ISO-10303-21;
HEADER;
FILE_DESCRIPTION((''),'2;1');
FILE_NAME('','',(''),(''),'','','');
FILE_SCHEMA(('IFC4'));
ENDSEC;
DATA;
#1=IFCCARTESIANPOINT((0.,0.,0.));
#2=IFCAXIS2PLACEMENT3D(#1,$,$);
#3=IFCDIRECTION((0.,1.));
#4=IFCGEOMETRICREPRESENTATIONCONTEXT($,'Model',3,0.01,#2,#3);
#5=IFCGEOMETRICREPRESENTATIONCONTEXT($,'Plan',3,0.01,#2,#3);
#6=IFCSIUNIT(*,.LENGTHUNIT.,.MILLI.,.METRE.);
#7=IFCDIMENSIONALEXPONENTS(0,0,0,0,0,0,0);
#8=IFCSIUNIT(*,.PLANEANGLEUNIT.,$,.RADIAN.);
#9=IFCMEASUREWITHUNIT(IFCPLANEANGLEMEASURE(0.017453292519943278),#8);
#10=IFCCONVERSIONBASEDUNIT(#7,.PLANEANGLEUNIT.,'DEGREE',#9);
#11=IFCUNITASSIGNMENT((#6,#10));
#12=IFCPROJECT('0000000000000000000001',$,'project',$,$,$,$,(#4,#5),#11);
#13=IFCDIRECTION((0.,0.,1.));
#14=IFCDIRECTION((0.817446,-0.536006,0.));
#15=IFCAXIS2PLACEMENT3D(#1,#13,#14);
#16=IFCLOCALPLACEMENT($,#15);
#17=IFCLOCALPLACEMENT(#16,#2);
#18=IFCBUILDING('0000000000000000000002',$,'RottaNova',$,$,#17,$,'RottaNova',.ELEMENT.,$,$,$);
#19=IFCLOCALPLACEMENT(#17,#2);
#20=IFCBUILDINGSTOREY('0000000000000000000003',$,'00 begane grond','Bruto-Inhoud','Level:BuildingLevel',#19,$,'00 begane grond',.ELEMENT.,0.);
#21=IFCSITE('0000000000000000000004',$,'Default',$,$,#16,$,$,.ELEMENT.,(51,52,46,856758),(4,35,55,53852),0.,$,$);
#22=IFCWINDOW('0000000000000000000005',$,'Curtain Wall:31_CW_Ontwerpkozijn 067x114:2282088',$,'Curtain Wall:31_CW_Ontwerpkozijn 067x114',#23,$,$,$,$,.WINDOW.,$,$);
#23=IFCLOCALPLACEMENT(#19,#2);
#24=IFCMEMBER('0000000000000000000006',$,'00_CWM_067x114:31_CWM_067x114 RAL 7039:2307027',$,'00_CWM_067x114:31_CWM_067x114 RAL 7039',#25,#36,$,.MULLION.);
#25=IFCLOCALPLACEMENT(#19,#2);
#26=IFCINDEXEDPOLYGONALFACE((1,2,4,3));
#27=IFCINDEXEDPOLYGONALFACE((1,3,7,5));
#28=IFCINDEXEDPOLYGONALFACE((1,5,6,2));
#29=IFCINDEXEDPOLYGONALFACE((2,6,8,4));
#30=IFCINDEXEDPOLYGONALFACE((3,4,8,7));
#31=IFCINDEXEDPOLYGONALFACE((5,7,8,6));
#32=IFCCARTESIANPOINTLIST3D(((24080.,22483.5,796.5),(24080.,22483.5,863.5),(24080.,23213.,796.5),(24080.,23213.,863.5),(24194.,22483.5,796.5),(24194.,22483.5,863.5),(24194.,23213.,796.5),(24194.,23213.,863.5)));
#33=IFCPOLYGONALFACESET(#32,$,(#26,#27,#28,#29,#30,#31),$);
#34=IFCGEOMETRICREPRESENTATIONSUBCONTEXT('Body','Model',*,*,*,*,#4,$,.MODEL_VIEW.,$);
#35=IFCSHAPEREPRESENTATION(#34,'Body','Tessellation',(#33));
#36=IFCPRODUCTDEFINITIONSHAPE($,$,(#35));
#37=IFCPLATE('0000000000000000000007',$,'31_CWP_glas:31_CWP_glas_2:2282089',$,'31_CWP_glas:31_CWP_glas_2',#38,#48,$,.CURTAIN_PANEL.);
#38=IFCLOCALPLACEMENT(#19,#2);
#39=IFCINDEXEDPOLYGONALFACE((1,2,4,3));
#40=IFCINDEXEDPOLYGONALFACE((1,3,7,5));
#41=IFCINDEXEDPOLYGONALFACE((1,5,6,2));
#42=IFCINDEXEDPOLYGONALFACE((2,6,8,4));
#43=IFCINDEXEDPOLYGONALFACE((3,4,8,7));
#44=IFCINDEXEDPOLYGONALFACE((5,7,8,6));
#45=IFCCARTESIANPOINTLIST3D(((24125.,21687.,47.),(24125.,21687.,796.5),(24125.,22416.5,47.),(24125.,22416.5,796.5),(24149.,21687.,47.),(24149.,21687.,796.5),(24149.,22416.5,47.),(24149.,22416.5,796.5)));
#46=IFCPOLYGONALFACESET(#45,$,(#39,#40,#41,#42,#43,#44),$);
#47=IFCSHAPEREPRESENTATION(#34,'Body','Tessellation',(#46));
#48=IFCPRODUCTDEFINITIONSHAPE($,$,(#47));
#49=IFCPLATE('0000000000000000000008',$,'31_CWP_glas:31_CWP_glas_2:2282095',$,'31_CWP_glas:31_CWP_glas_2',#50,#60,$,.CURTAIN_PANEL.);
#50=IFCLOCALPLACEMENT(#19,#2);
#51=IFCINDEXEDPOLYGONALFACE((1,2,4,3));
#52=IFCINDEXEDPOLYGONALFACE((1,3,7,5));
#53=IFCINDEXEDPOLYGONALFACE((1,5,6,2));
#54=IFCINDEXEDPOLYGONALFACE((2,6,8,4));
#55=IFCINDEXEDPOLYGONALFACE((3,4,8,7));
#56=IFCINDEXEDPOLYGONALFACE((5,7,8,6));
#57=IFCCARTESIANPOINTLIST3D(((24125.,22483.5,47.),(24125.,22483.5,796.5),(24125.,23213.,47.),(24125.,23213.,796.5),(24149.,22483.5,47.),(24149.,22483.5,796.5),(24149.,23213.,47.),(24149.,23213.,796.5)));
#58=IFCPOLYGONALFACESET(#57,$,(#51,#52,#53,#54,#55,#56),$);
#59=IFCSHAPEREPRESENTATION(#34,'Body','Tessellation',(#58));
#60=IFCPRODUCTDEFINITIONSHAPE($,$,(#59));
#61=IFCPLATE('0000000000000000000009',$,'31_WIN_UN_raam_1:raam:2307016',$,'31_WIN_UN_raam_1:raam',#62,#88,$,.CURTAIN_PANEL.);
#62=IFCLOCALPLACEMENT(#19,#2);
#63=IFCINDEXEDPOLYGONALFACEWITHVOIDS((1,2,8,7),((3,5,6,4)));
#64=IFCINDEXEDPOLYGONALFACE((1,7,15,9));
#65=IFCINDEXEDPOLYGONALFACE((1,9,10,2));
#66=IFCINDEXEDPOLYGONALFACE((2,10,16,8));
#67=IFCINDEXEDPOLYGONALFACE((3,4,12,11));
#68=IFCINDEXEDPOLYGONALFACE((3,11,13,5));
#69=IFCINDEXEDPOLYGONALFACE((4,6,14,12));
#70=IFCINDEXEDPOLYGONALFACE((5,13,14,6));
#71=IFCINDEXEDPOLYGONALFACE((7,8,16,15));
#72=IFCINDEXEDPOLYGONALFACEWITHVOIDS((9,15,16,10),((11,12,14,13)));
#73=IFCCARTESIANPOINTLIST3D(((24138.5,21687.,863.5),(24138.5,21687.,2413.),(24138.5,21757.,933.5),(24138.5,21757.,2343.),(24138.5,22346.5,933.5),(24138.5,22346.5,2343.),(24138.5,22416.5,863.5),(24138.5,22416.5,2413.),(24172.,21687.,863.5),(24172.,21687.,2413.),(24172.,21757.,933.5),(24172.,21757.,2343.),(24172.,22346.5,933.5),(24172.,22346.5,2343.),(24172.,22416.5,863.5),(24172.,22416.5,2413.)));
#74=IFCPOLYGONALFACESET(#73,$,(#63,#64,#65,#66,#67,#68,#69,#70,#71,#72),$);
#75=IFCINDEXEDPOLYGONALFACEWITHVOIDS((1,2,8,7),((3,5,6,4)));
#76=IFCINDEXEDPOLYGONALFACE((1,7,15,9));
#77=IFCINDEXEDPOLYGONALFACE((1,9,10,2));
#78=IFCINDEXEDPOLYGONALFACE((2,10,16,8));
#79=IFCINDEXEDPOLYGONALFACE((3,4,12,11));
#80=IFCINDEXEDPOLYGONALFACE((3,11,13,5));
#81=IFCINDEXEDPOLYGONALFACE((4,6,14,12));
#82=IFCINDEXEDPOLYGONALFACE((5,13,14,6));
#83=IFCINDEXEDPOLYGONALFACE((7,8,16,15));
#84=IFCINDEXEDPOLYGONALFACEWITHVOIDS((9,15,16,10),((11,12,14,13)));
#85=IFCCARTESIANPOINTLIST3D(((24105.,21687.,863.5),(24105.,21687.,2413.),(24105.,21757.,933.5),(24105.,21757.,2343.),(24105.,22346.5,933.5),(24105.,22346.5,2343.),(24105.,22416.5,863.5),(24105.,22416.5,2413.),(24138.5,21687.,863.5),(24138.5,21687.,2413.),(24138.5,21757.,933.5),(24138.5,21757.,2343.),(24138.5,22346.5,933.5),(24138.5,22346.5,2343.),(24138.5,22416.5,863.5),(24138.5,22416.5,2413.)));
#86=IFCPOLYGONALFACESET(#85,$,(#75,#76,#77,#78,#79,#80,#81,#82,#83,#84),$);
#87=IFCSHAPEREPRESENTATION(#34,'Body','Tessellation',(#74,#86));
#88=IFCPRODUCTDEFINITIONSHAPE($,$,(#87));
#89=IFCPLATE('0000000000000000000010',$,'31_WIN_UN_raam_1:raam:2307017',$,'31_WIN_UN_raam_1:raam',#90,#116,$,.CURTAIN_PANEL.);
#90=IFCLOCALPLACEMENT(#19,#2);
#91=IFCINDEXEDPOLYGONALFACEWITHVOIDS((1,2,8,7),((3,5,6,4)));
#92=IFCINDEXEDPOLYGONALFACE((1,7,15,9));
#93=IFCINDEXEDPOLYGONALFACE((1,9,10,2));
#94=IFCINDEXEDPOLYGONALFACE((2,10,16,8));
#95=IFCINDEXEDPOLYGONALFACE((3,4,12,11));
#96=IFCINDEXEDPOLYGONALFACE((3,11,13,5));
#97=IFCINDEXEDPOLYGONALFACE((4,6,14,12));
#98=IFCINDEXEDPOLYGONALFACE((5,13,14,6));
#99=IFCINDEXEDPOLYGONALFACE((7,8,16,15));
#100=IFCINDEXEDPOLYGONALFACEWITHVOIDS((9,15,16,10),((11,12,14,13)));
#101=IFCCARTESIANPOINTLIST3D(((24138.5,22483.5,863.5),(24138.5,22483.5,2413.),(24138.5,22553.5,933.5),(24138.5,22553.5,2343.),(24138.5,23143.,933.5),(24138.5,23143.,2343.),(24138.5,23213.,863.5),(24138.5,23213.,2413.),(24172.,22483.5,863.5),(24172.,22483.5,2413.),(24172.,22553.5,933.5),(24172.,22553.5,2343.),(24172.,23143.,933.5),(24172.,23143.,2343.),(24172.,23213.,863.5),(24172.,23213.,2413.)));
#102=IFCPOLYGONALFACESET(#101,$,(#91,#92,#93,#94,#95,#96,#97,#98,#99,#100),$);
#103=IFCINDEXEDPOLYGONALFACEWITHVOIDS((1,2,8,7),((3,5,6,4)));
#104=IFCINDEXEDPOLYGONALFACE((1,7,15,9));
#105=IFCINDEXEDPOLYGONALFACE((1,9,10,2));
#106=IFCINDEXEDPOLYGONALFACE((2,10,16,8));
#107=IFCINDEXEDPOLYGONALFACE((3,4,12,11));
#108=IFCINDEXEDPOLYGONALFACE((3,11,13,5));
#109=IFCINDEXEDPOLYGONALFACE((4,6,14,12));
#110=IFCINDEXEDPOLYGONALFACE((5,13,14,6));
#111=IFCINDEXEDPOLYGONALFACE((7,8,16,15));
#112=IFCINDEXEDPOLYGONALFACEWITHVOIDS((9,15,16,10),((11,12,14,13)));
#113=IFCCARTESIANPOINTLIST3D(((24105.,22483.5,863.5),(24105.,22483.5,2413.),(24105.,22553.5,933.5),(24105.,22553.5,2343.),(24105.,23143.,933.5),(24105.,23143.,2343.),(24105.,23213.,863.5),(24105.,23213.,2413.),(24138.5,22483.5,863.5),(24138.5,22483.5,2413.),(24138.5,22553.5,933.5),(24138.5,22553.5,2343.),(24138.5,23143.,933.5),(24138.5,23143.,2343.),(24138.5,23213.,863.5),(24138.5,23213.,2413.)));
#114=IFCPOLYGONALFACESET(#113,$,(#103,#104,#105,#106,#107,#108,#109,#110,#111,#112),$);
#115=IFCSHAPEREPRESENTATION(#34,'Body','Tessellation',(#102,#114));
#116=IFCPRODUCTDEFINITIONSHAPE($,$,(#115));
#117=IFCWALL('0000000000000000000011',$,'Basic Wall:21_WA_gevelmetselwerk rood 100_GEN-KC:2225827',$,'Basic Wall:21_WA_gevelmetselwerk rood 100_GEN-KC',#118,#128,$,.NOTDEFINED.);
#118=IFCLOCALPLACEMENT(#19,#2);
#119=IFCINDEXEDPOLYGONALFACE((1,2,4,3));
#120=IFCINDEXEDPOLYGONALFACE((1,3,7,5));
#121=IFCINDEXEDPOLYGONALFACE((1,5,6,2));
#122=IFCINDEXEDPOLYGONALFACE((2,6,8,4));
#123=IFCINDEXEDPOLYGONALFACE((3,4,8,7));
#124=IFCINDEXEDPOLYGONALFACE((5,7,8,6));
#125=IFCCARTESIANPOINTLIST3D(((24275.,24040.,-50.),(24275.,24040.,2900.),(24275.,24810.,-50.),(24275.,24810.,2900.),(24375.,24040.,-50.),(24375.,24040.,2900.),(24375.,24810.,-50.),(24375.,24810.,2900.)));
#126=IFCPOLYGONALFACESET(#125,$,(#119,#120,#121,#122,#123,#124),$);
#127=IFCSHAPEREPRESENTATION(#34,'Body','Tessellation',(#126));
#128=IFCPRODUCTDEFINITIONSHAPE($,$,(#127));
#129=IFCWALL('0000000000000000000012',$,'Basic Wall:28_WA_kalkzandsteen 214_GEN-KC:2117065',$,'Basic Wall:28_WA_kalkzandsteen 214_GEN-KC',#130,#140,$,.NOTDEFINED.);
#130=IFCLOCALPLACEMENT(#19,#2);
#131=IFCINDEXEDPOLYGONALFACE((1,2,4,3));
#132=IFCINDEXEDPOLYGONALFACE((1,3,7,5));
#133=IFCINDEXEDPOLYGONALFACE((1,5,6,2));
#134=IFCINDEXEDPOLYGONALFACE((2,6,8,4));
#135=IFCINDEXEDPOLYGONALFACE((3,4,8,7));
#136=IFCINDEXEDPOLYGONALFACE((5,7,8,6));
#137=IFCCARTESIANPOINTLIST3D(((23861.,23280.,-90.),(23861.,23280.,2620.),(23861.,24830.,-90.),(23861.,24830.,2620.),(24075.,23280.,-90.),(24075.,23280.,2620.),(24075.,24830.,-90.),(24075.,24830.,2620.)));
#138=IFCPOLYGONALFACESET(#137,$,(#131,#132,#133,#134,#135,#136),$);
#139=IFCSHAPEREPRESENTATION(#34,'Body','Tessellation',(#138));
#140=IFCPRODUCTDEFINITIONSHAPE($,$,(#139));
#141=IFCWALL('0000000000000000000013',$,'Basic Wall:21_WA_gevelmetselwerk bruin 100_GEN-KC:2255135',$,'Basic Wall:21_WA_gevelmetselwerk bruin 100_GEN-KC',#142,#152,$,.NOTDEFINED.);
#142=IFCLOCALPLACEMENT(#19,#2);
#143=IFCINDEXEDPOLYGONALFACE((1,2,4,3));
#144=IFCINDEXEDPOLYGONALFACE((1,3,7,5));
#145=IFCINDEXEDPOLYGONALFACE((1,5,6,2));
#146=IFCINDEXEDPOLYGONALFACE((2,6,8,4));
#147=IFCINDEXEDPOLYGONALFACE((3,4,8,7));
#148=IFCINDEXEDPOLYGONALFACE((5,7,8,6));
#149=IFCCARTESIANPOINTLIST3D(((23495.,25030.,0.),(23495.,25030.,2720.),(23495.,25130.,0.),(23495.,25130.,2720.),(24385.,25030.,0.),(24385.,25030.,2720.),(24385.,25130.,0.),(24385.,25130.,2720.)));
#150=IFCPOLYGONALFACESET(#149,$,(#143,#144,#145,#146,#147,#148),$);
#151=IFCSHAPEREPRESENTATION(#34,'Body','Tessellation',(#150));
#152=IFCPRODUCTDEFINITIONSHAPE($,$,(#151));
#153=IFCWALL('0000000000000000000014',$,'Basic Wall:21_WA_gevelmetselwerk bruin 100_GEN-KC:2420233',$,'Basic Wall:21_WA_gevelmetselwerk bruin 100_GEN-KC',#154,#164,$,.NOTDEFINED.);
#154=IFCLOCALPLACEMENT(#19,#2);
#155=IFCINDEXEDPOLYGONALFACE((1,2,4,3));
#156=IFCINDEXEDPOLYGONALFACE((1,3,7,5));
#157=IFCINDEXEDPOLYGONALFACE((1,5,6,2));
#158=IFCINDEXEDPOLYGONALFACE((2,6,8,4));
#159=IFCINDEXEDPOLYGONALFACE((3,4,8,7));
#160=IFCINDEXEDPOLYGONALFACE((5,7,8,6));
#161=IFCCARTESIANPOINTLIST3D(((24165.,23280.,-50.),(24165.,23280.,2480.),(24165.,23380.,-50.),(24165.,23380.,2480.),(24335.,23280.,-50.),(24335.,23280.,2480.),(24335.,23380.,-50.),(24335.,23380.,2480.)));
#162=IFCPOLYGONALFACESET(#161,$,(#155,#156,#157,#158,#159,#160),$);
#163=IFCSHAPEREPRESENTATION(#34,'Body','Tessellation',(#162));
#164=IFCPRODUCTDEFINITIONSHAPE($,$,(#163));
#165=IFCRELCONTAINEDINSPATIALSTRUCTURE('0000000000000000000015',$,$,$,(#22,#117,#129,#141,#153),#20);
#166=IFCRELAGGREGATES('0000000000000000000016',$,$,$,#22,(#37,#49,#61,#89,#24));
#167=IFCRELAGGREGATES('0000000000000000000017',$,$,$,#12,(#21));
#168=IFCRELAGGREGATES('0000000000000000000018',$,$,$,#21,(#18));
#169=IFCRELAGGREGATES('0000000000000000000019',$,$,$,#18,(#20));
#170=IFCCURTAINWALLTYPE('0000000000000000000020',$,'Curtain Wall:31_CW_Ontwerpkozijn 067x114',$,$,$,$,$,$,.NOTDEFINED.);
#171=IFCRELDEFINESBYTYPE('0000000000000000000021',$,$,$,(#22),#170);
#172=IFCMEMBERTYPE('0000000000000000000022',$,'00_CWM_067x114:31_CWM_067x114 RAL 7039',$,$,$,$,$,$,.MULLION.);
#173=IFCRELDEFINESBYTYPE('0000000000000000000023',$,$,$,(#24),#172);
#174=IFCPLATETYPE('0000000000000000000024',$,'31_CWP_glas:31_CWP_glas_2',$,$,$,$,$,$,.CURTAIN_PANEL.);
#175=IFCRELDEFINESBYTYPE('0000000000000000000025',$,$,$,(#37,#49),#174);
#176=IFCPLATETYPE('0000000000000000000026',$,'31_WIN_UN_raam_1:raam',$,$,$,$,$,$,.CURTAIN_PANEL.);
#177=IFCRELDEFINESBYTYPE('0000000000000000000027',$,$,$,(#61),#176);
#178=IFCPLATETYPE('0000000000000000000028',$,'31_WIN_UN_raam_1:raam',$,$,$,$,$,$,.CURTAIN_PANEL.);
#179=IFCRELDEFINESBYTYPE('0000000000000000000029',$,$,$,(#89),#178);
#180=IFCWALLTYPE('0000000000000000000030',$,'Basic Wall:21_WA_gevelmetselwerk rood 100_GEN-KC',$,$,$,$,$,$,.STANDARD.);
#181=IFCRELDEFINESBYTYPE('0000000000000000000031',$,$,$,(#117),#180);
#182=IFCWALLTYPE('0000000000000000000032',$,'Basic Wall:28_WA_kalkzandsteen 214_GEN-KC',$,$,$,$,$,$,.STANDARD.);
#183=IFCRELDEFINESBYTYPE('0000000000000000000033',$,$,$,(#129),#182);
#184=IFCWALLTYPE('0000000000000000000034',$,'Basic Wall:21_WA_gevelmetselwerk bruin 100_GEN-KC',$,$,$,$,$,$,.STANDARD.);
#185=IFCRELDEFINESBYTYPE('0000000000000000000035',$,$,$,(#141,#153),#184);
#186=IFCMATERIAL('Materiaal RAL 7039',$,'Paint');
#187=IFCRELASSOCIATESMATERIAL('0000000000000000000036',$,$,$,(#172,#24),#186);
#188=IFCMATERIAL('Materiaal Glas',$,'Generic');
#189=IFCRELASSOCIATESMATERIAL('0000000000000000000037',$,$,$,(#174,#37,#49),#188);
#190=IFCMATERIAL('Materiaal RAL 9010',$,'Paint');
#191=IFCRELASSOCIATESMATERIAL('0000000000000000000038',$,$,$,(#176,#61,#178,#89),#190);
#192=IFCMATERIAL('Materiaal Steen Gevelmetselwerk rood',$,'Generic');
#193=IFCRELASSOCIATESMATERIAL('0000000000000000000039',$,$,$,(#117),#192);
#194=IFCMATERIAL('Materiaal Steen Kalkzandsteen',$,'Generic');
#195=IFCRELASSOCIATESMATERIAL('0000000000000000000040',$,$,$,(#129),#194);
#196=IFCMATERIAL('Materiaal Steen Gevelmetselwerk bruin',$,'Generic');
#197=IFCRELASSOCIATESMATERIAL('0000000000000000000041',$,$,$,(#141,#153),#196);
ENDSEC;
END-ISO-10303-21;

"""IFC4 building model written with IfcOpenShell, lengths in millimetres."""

from ifc_helpers import new_model, entity, si_unit, converted_unit, direction, frame, origin, place, context, subcontext, project, spatial, indexed_curve, outline, extrude, source, transform, mapped, material, type_object, type_shapes, element, aggregate, save


model = new_model("IFC4")

# Units and contexts
model_context = context("Model", 3, precision=0.01, world=origin(), true_north=direction((0.0, 1.0)))
plan_context = context("Plan", 3, precision=0.01, world=origin(), true_north=direction((0.0, 1.0)))
body_context = subcontext(model_context, "Body", "Model", "MODEL_VIEW")
ifc_project = project(units=[si_unit("LENGTHUNIT", "METRE", prefix="MILLI"), converted_unit("PLANEANGLEUNIT", "DEGREE", entity("IfcPlaneAngleMeasure", 0.017453292519943278), si_unit("PLANEANGLEUNIT", "RADIAN"), dimensions=[0, 0, 0, 0, 0, 0, 0])], contexts=[model_context, plan_context])

# Site, building, storey
site_placement = place(None, frame((0.0, 0.0, 0.0), z_axis=(0.0, 0.0, 1.0), x_axis=(0.817446, -0.536006, 0.0)))
site = spatial("IfcSite", under=ifc_project, at=site_placement, Name="Default", CompositionType="ELEMENT", RefLatitude=(51, 52, 46, 856758), RefLongitude=(4, 35, 55, 53852), RefElevation=0.0)
building_placement = place(site_placement, origin())
building = spatial("IfcBuilding", under=site, at=building_placement, Name="RottaNova", LongName="RottaNova", CompositionType="ELEMENT")
storey_placement = place(building_placement, origin())
storey = spatial("IfcBuildingStorey", under=building, at=storey_placement, Name="00 begane grond", Description="Bruto-Inhoud", ObjectType="Level:BuildingLevel", LongName="00 begane grond", CompositionType="ELEMENT", Elevation=0.0)

# Window, member, plates
curtain_wall_type = type_object("IfcCurtainWallType", Name="Curtain Wall:31_CW_Ontwerpkozijn 067x114", PredefinedType="NOTDEFINED")
window_placement = place(storey_placement, origin())
window = element("IfcWindow", 1, at=window_placement, inside=storey, type_object=curtain_wall_type, Name="Curtain Wall:31_CW_Ontwerpkozijn 067x114:2282088", ObjectType="Curtain Wall:31_CW_Ontwerpkozijn 067x114", PredefinedType="WINDOW")
ifc_material_1 = material(Name="Materiaal RAL 7039", Category="Paint")
member_type_1 = type_object("IfcMemberType", Name="00_CWM_067x114:31_CWM_067x114 RAL 7039", PredefinedType="MULLION", material=ifc_material_1)
shared_shape_1 = source(origin(), body_context, "Body", "SweptSolid", [
    extrude(outline(indexed_curve([(-33.5, -57.0), (33.5, -57.0), (33.5, 57.0), (-33.5, 57.0), (-33.5, -57.0)], self_intersect=False)), frame((0.0, 57.0, -729.5), z_axis=(0.0, 0.0, 1.0), x_axis=(-1.0, 0.0, 0.0)), (0.0, 0.0, 1.0), 729.5),
])
type_shapes(member_type_1, [shared_shape_1])
member_1_placement = place(window_placement, frame((24080.0, 23213.0, 830.0), z_axis=(0.0, 1.0, 0.0), x_axis=(0.0, 0.0, 1.0)))
member_1 = element("IfcMember", 2, at=member_1_placement, type_object=member_type_1, material=ifc_material_1, Name="00_CWM_067x114:31_CWM_067x114 RAL 7039:2307027", ObjectType="00_CWM_067x114:31_CWM_067x114 RAL 7039", PredefinedType="MULLION", context=body_context, shape_type="MappedRepresentation", body=[
    mapped(shared_shape_1, transform((0.0, 0.0, 0.0), scale=1.0)),
])
ifc_material_2 = material(Name="Materiaal Glas", Category="Generic")
plate_type_1 = type_object("IfcPlateType", Name="31_CWP_glas:31_CWP_glas_2", PredefinedType="CURTAIN_PANEL", material=ifc_material_2)
shared_shape_2 = source(origin(), body_context, "Body", "SweptSolid", [
    extrude(outline(indexed_curve([(-12.0, -364.7), (12.0, -364.7), (12.0, 364.7), (-12.0, 364.7), (-12.0, -364.7)], self_intersect=False)), frame((0.0, -57.0, 0.0), z_axis=(0.0, 0.0, 1.0), x_axis=(0.0, 1.0, 0.0)), (0.0, 0.0, 1.0), 749.5),
])
type_shapes(plate_type_1, [shared_shape_2])
plate_1_placement = place(window_placement, frame((24080.0, 22051.7, 47.0), z_axis=(0.0, 0.0, 1.0), x_axis=(0.0, 1.0, 0.0)))
plate_1 = element("IfcPlate", 3, at=plate_1_placement, type_object=plate_type_1, material=ifc_material_2, Name="31_CWP_glas:31_CWP_glas_2:2282089", ObjectType="31_CWP_glas:31_CWP_glas_2", PredefinedType="CURTAIN_PANEL", context=body_context, shape_type="MappedRepresentation", body=[
    mapped(shared_shape_2, transform((0.0, 0.0, 0.0), scale=1.0)),
])
plate_2_placement = place(window_placement, frame((24080.0, 22848.2, 47.0), z_axis=(0.0, 0.0, 1.0), x_axis=(0.0, 1.0, 0.0)))
plate_2 = element("IfcPlate", 4, at=plate_2_placement, type_object=plate_type_1, material=ifc_material_2, Name="31_CWP_glas:31_CWP_glas_2:2282095", ObjectType="31_CWP_glas:31_CWP_glas_2", PredefinedType="CURTAIN_PANEL", context=body_context, shape_type="MappedRepresentation", body=[
    mapped(shared_shape_2, transform((0.0, 0.0, 0.0), scale=1.0)),
])
ifc_material_3 = material(Name="Materiaal RAL 9010", Category="Paint")
plate_type_2 = type_object("IfcPlateType", Name="31_WIN_UN_raam_1:raam", PredefinedType="CURTAIN_PANEL", material=ifc_material_3)
shared_shape_3 = source(origin(), body_context, "Body", "SweptSolid", [
    extrude(outline(indexed_curve([(-364.7, -774.7), (364.7, -774.7), (364.7, 774.7), (-364.7, 774.7), (-364.7, -774.7)], self_intersect=False), holes=[indexed_curve([(-294.7, 704.7), (294.7, 704.7), (294.7, -704.8), (-294.7, -704.8), (-294.7, 704.7)], self_intersect=False)]), frame((0.0, -92.0, 774.8), z_axis=(0.0, 1.0, 0.0), x_axis=(1.0, 0.0, 0.0)), (0.0, 0.0, 1.0), 33.5),
    extrude(outline(indexed_curve([(-364.7, -774.7), (364.7, -774.7), (364.7, 774.7), (-364.7, 774.7), (-364.7, -774.7)], self_intersect=False), holes=[indexed_curve([(-294.7, 704.7), (294.7, 704.7), (294.7, -704.8), (-294.7, -704.8), (-294.7, 704.7)], self_intersect=False)]), frame((0.0, -58.5, 774.8), z_axis=(0.0, 1.0, 0.0), x_axis=(1.0, 0.0, 0.0)), (0.0, 0.0, 1.0), 33.5),
])
type_shapes(plate_type_2, [shared_shape_3])
plate_3_placement = place(window_placement, frame((24080.0, 22051.7, 863.5), z_axis=(0.0, 0.0, 1.0), x_axis=(0.0, 1.0, 0.0)))
plate_3 = element("IfcPlate", 5, at=plate_3_placement, type_object=plate_type_2, material=ifc_material_3, Name="31_WIN_UN_raam_1:raam:2307016", ObjectType="31_WIN_UN_raam_1:raam", PredefinedType="CURTAIN_PANEL", context=body_context, shape_type="MappedRepresentation", body=[
    mapped(shared_shape_3, transform((0.0, 0.0, 0.0), scale=1.0)),
])
plate_type_3 = type_object("IfcPlateType", Name="31_WIN_UN_raam_1:raam", PredefinedType="CURTAIN_PANEL", material=ifc_material_3)
shared_shape_4 = source(origin(), body_context, "Body", "SweptSolid", [
    extrude(outline(indexed_curve([(-364.7, -774.7), (364.7, -774.7), (364.7, 774.7), (-364.7, 774.7), (-364.7, -774.7)], self_intersect=False), holes=[indexed_curve([(-294.7, 704.7), (294.7, 704.7), (294.7, -704.8), (-294.7, -704.8), (-294.7, 704.7)], self_intersect=False)]), frame((0.0, -92.0, 774.8), z_axis=(0.0, 1.0, 0.0), x_axis=(1.0, 0.0, 0.0)), (0.0, 0.0, 1.0), 33.5),
    extrude(outline(indexed_curve([(-364.7, -774.7), (364.7, -774.7), (364.7, 774.7), (-364.7, 774.7), (-364.7, -774.7)], self_intersect=False), holes=[indexed_curve([(-294.7, 704.7), (294.7, 704.7), (294.7, -704.8), (-294.7, -704.8), (-294.7, 704.7)], self_intersect=False)]), frame((0.0, -58.5, 774.8), z_axis=(0.0, 1.0, 0.0), x_axis=(1.0, 0.0, 0.0)), (0.0, 0.0, 1.0), 33.5),
])
type_shapes(plate_type_3, [shared_shape_4])
plate_4_placement = place(window_placement, frame((24080.0, 22848.2, 863.5), z_axis=(0.0, 0.0, 1.0), x_axis=(0.0, 1.0, 0.0)))
plate_4 = element("IfcPlate", 6, at=plate_4_placement, type_object=plate_type_3, material=ifc_material_3, Name="31_WIN_UN_raam_1:raam:2307017", ObjectType="31_WIN_UN_raam_1:raam", PredefinedType="CURTAIN_PANEL", context=body_context, shape_type="MappedRepresentation", body=[
    mapped(shared_shape_4, transform((0.0, 0.0, 0.0), scale=1.0)),
])
aggregate(window, [plate_1, plate_2, plate_3, plate_4, member_1])

# Walls
ifc_material_4 = material(Name="Materiaal Steen Gevelmetselwerk rood", Category="Generic")
wall_type_1 = type_object("IfcWallType", Name="Basic Wall:21_WA_gevelmetselwerk rood 100_GEN-KC", PredefinedType="STANDARD")
wall_1_placement = place(storey_placement, frame((24325.0, 24810.0, -50.0), z_axis=(0.0, 0.0, 1.0), x_axis=(0.0, -1.0, 0.0)))
element("IfcWall", 7, at=wall_1_placement, inside=storey, type_object=wall_type_1, material=ifc_material_4, Name="Basic Wall:21_WA_gevelmetselwerk rood 100_GEN-KC:2225827", ObjectType="Basic Wall:21_WA_gevelmetselwerk rood 100_GEN-KC", PredefinedType="NOTDEFINED", context=body_context, shape_type="SweptSolid", body=[
    extrude(outline(indexed_curve([(770.0, 50.0), (0.0, 50.0), (0.0, -50.0), (770.0, -50.0), (770.0, 50.0)], self_intersect=False)), origin(), (0.0, 0.0, 1.0), 2950.0),
])
ifc_material_5 = material(Name="Materiaal Steen Kalkzandsteen", Category="Generic")
wall_type_2 = type_object("IfcWallType", Name="Basic Wall:28_WA_kalkzandsteen 214_GEN-KC", PredefinedType="STANDARD")
wall_2_placement = place(storey_placement, frame((23968.0, 24830.0, -90.0), z_axis=(0.0, 0.0, 1.0), x_axis=(0.0, -1.0, 0.0)))
element("IfcWall", 8, at=wall_2_placement, inside=storey, type_object=wall_type_2, material=ifc_material_5, Name="Basic Wall:28_WA_kalkzandsteen 214_GEN-KC:2117065", ObjectType="Basic Wall:28_WA_kalkzandsteen 214_GEN-KC", PredefinedType="NOTDEFINED", context=body_context, shape_type="SweptSolid", body=[
    extrude(outline(indexed_curve([(1550.0, 107.0), (0.0, 107.0), (0.0, -107.0), (1550.0, -107.0), (1550.0, 107.0)], self_intersect=False)), origin(), (0.0, 0.0, 1.0), 2710.0),
])
ifc_material_6 = material(Name="Materiaal Steen Gevelmetselwerk bruin", Category="Generic")
wall_type_3 = type_object("IfcWallType", Name="Basic Wall:21_WA_gevelmetselwerk bruin 100_GEN-KC", PredefinedType="STANDARD")
wall_3_placement = place(storey_placement, frame((24385.0, 25080.0, 0.0), z_axis=(0.0, 0.0, 1.0), x_axis=(-1.0, 0.0, 0.0)))
element("IfcWall", 9, at=wall_3_placement, inside=storey, type_object=wall_type_3, material=ifc_material_6, Name="Basic Wall:21_WA_gevelmetselwerk bruin 100_GEN-KC:2255135", ObjectType="Basic Wall:21_WA_gevelmetselwerk bruin 100_GEN-KC", PredefinedType="NOTDEFINED", context=body_context, shape_type="SweptSolid", body=[
    extrude(outline(indexed_curve([(890.0, 50.0), (0.0, 50.0), (0.0, -50.0), (890.0, -50.0), (890.0, 50.0)], self_intersect=False)), origin(), (0.0, 0.0, 1.0), 2720.0),
])
wall_4_placement = place(storey_placement, frame((24335.0, 23330.0, -50.0), z_axis=(0.0, 0.0, 1.0), x_axis=(-1.0, 0.0, 0.0)))
element("IfcWall", 10, at=wall_4_placement, inside=storey, type_object=wall_type_3, material=ifc_material_6, Name="Basic Wall:21_WA_gevelmetselwerk bruin 100_GEN-KC:2420233", ObjectType="Basic Wall:21_WA_gevelmetselwerk bruin 100_GEN-KC", PredefinedType="NOTDEFINED", context=body_context, shape_type="SweptSolid", body=[
    extrude(outline(indexed_curve([(170.0, 50.0), (0.0, 50.0), (0.0, -50.0), (170.0, -50.0), (170.0, 50.0)], self_intersect=False)), origin(), (0.0, 0.0, 1.0), 2530.0),
])

save(model, "model.ifc")
